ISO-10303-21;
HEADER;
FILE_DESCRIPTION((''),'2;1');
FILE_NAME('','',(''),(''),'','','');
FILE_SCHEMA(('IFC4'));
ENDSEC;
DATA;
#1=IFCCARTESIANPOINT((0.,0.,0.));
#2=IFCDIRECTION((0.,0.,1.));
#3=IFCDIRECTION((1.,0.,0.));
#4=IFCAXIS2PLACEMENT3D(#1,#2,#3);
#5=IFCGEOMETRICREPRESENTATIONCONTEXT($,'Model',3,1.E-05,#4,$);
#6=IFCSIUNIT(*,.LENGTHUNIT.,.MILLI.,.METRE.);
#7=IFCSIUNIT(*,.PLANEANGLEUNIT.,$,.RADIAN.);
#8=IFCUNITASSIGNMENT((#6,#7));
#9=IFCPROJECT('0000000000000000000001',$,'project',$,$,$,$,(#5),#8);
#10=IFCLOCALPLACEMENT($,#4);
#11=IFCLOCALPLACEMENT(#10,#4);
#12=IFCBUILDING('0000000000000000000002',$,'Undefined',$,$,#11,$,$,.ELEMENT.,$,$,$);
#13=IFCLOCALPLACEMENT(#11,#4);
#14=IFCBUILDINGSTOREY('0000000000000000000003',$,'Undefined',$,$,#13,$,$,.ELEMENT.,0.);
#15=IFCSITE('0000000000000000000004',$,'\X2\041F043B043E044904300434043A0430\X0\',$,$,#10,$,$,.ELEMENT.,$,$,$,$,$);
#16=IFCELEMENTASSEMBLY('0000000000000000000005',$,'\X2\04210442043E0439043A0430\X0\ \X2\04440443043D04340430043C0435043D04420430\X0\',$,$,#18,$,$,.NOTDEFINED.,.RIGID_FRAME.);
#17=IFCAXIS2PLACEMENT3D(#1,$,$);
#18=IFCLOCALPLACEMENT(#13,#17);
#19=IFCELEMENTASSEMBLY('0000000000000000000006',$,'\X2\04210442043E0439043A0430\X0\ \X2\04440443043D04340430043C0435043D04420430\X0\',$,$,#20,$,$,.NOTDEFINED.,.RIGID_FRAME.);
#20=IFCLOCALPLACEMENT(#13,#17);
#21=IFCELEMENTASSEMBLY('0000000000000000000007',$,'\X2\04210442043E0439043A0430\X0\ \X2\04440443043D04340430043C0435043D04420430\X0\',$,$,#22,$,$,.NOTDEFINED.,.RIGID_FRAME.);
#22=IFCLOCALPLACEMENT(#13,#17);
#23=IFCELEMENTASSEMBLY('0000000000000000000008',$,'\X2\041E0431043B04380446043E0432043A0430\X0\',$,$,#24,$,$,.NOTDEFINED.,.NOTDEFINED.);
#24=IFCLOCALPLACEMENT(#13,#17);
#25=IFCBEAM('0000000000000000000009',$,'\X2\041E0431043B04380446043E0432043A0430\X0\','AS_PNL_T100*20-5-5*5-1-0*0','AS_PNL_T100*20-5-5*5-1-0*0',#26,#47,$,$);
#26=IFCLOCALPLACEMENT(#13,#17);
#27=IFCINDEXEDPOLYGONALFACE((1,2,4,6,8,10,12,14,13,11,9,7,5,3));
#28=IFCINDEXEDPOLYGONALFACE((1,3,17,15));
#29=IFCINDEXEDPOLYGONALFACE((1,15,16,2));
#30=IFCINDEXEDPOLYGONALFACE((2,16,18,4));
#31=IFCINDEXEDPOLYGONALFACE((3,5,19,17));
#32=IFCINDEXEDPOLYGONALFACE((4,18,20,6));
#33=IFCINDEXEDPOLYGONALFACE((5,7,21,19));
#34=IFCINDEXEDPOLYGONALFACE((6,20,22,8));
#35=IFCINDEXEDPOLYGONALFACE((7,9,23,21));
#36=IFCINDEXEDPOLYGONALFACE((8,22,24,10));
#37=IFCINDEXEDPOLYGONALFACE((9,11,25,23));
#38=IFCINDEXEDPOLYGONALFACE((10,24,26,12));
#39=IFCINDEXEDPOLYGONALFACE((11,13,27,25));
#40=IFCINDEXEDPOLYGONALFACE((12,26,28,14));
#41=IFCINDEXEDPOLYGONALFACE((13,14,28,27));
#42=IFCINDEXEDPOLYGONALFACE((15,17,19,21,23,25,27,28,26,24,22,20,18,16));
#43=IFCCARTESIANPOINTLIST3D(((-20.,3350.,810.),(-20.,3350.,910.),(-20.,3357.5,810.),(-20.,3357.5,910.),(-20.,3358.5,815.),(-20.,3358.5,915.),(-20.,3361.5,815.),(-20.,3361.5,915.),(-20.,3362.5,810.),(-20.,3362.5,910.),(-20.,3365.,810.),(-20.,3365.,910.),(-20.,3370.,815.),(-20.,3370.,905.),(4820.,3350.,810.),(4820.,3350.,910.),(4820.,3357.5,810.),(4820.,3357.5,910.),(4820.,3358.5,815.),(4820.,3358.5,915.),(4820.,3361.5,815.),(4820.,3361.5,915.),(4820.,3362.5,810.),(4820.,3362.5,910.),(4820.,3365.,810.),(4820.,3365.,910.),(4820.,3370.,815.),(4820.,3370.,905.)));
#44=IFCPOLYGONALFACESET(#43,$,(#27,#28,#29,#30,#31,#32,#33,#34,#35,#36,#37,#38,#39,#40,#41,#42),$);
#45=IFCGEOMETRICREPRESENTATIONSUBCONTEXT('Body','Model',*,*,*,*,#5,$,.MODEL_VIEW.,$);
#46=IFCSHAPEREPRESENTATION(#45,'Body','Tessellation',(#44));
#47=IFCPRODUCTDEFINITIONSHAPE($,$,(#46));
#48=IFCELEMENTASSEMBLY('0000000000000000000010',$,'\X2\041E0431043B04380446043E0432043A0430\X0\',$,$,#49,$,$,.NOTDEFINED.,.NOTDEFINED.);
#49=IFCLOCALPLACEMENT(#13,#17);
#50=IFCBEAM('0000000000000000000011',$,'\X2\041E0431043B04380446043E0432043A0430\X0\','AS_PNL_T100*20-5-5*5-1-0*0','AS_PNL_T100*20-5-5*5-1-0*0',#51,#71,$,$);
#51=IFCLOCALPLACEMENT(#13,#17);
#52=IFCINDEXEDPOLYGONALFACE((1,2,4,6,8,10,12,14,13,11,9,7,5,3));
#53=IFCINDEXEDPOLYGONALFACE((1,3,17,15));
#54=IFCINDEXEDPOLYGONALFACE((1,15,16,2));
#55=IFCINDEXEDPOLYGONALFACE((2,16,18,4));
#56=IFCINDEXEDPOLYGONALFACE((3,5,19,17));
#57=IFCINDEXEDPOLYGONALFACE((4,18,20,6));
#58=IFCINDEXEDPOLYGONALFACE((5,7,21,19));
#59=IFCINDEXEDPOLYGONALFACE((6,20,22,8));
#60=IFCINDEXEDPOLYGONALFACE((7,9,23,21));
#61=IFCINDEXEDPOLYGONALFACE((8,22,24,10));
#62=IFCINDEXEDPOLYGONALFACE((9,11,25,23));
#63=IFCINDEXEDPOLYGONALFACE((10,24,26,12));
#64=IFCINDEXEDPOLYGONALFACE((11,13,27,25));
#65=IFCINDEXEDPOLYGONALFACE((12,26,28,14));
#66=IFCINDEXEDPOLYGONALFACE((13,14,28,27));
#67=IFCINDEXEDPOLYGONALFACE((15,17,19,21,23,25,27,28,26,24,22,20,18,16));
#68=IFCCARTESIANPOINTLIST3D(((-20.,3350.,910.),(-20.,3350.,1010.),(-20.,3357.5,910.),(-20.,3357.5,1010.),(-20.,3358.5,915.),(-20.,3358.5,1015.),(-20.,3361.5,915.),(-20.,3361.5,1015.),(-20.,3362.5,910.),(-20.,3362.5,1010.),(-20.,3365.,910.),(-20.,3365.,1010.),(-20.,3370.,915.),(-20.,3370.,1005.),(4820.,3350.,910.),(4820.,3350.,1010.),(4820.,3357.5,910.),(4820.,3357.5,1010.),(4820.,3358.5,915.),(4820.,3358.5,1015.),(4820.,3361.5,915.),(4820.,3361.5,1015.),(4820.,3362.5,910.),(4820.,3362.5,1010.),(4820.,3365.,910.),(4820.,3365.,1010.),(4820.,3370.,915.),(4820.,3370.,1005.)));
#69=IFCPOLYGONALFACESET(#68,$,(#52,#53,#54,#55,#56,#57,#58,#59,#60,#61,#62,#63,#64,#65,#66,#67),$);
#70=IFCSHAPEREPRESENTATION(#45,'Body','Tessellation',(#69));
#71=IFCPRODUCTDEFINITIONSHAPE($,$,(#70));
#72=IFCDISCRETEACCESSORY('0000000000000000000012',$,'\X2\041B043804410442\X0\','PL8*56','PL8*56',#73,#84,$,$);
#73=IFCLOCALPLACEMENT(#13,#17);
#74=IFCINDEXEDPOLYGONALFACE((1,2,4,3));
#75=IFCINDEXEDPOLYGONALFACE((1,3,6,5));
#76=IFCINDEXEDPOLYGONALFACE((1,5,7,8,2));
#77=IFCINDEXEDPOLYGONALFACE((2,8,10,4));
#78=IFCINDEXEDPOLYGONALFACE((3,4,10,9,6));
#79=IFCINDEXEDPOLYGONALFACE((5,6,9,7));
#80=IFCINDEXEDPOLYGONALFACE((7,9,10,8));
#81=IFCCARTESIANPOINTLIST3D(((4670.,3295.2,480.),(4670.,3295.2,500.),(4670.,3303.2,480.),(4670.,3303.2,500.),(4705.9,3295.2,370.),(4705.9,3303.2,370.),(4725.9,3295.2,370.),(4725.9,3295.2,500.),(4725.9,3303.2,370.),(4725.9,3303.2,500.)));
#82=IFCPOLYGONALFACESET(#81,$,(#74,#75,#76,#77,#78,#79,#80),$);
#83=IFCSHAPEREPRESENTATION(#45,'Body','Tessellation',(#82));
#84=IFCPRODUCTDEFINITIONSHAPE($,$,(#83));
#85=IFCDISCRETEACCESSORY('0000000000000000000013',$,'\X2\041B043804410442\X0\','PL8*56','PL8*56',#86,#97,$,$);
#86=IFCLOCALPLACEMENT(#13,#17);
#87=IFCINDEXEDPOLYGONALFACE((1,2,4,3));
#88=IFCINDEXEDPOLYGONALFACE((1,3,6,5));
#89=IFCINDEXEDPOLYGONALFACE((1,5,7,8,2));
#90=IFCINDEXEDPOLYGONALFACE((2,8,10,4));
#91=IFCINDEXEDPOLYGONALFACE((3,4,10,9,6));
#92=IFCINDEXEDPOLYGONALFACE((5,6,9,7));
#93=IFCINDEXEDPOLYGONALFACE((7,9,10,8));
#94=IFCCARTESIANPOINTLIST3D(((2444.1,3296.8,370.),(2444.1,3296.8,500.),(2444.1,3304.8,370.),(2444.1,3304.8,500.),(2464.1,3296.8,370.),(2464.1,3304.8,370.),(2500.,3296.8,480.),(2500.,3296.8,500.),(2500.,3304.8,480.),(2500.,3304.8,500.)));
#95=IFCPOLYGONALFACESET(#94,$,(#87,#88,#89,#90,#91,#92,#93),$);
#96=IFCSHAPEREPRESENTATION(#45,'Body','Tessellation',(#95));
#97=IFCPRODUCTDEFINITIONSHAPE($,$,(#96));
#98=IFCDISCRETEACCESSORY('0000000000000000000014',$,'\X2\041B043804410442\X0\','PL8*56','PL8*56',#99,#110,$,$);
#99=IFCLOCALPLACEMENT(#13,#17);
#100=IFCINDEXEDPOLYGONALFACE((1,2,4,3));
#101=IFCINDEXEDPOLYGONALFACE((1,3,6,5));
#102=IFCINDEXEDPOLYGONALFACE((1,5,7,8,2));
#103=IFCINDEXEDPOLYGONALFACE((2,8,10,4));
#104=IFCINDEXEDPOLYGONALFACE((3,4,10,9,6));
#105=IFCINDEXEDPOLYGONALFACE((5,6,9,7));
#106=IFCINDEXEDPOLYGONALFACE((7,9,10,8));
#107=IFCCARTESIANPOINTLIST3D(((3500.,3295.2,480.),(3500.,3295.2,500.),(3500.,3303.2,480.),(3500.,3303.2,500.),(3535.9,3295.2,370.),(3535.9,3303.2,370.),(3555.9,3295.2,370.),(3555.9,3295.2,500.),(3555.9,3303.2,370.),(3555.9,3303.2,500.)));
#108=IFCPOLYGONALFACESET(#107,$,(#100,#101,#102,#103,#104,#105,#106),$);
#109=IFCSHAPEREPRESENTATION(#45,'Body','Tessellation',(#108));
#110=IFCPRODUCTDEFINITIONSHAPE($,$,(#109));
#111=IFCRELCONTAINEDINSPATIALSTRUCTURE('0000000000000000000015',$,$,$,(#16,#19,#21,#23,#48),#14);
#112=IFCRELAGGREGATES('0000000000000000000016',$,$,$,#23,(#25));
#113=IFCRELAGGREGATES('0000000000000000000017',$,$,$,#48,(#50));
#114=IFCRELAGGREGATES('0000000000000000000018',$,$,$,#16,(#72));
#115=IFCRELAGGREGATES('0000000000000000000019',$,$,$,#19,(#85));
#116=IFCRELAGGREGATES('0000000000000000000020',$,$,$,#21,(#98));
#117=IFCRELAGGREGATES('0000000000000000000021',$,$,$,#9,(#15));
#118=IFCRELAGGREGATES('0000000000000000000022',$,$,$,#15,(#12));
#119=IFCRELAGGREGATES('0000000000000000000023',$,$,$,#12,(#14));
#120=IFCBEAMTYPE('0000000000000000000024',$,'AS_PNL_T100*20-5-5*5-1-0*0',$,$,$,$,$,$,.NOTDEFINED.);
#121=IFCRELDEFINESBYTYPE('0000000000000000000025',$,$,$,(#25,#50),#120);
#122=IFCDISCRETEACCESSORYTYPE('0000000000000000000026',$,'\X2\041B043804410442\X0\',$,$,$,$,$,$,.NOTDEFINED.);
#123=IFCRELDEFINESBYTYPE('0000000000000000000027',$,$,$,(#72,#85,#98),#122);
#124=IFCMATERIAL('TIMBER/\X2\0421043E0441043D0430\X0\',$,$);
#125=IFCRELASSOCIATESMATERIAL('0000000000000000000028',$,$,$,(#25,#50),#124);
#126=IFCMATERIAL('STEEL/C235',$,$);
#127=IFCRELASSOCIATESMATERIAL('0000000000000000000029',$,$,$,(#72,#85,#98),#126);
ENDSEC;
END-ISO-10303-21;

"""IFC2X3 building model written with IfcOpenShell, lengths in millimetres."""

from ifc_helpers import new_model, si_unit, frame, origin_with_axes, place, context, subcontext, project, spatial, polyline, outline, extrude, material, type_object, element, aggregate, save


model = new_model("IFC2X3")

# Units and contexts
model_context = context("Model", 3, precision=1e-05, world=origin_with_axes())
body_context = subcontext(model_context, "Body", "Model", "MODEL_VIEW")
ifc_project = project(units=[si_unit("LENGTHUNIT", "METRE", prefix="MILLI"), si_unit("PLANEANGLEUNIT", "RADIAN")], contexts=[model_context])

# Site, building, storey
site_placement = place(None, origin_with_axes())
site = spatial("IfcSite", under=ifc_project, at=site_placement, Name="Площадка", CompositionType="ELEMENT")
building_placement = place(site_placement, origin_with_axes())
building = spatial("IfcBuilding", under=site, at=building_placement, Name="Undefined", CompositionType="ELEMENT")
storey_placement = place(building_placement, origin_with_axes())
storey = spatial("IfcBuildingStorey", under=building, at=storey_placement, Name="Undefined", CompositionType="ELEMENT", Elevation=0.0)

# Element assemblies
assembly_1_placement = place(storey_placement, origin_with_axes())
assembly_1 = element("IfcElementAssembly", 1, at=assembly_1_placement, inside=storey, Name="Стойка фундамента", AssemblyPlace="NOTDEFINED", PredefinedType="RIGID_FRAME")
ifc_material_1 = material(Name="STEEL/C235")
assembly_2_placement = place(storey_placement, origin_with_axes())
assembly_2 = element("IfcElementAssembly", 2, at=assembly_2_placement, inside=storey, Name="Стойка фундамента", AssemblyPlace="NOTDEFINED", PredefinedType="RIGID_FRAME")
assembly_3_placement = place(storey_placement, origin_with_axes())
assembly_3 = element("IfcElementAssembly", 3, at=assembly_3_placement, inside=storey, Name="Стойка фундамента", AssemblyPlace="NOTDEFINED", PredefinedType="RIGID_FRAME")

# Shared definitions
ifc_material_2 = material(Name="TIMBER/Сосна")

# Element assemblies, beams
beam_type_1 = type_object("IfcBeamType", Name="AS_PNL_T100*20-5-5*5-1-0*0", PredefinedType="NOTDEFINED")
assembly_4_placement = place(storey_placement, origin_with_axes())
assembly_4 = element("IfcElementAssembly", 4, at=assembly_4_placement, inside=storey, Name="Облицовка", AssemblyPlace="NOTDEFINED", PredefinedType="NOTDEFINED")
beam_1_placement = place(assembly_4_placement, frame((4820.0, 3360.0, 860.0), z_axis=(0.0, 0.0, 1.0), x_axis=(-1.0, 0.0, 0.0)))
beam_1 = element("IfcBeam", 5, at=beam_1_placement, type_object=beam_type_1, material=ifc_material_2, Name="Облицовка", Description="AS_PNL_T100*20-5-5*5-1-0*0", ObjectType="AS_PNL_T100*20-5-5*5-1-0*0", context=body_context, shape_type="SweptSolid", body=[
    extrude(outline(polyline([(-2.5, -50.0), (-10.0, -50.0), (-10.0, 50.0), (-2.5, 50.0), (-1.5, 55.0), (1.5, 55.0), (2.5, 50.0), (5.0, 50.0), (10.0, 45.0), (10.0, -45.0), (5.0, -50.0), (2.5, -50.0), (1.5, -45.0), (-1.5, -45.0), (-2.5, -50.0)])), frame((4840.0, 0.0, 0.0), z_axis=(-1.0, 0.0, 0.0), x_axis=(0.0, -1.0, 0.0)), (0.0, 0.0, 1.0), 4840.0),
])
aggregate(assembly_4, [beam_1])
assembly_5_placement = place(storey_placement, origin_with_axes())
assembly_5 = element("IfcElementAssembly", 6, at=assembly_5_placement, inside=storey, Name="Облицовка", AssemblyPlace="NOTDEFINED", PredefinedType="NOTDEFINED")
beam_2_placement = place(assembly_5_placement, frame((4820.0, 3360.0, 960.0), z_axis=(0.0, 0.0, 1.0), x_axis=(-1.0, 0.0, 0.0)))
beam_2 = element("IfcBeam", 7, at=beam_2_placement, type_object=beam_type_1, material=ifc_material_2, Name="Облицовка", Description="AS_PNL_T100*20-5-5*5-1-0*0", ObjectType="AS_PNL_T100*20-5-5*5-1-0*0", context=body_context, shape_type="SweptSolid", body=[
    extrude(outline(polyline([(-2.5, -50.0), (-10.0, -50.0), (-10.0, 50.0), (-2.5, 50.0), (-1.5, 55.0), (1.5, 55.0), (2.5, 50.0), (5.0, 50.0), (10.0, 45.0), (10.0, -45.0), (5.0, -50.0), (2.5, -50.0), (1.5, -45.0), (-1.5, -45.0), (-2.5, -50.0)])), frame((4840.0, 0.0, 0.0), z_axis=(-1.0, 0.0, 0.0), x_axis=(0.0, -1.0, 0.0)), (0.0, 0.0, 1.0), 4840.0),
])
aggregate(assembly_5, [beam_2])

# Discrete accessories
discrete_accessory_type = type_object("IfcDiscreteAccessoryType", Name="Лист")
discrete_accessory_1_placement = place(assembly_1_placement, frame((4725.9, 3299.2, 500.0), z_axis=(0.0, -1.0, 0.0), x_axis=(-1.0, 0.0, 0.0)))
discrete_accessory_1 = element("IfcDiscreteAccessory", 8, at=discrete_accessory_1_placement, type_object=discrete_accessory_type, material=ifc_material_1, Name="Лист", Description="PL8*56", ObjectType="PL8*56", context=body_context, shape_type="SweptSolid", body=[
    extrude(outline(polyline([(0.0, 0.0), (55.9, 0.0), (55.9, 20.0), (20.0, 130.0), (0.0, 130.0), (0.0, 0.0)])), frame((0.0, 0.0, -4.0), z_axis=(0.0, 0.0, 1.0), x_axis=(1.0, 0.0, 0.0)), (0.0, 0.0, 1.0), 8.0),
])
aggregate(assembly_1, [discrete_accessory_1])
discrete_accessory_2_placement = place(assembly_2_placement, frame((2444.1, 3300.8, 500.0), z_axis=(0.0, 1.0, 0.0), x_axis=(1.0, 0.0, 0.0)))
discrete_accessory_2 = element("IfcDiscreteAccessory", 9, at=discrete_accessory_2_placement, type_object=discrete_accessory_type, material=ifc_material_1, Name="Лист", Description="PL8*56", ObjectType="PL8*56", context=body_context, shape_type="SweptSolid", body=[
    extrude(outline(polyline([(0.0, 0.0), (55.9, 0.0), (55.9, 20.0), (20.0, 130.0), (0.0, 130.0), (0.0, 0.0)])), frame((0.0, 0.0, -4.0), z_axis=(0.0, 0.0, 1.0), x_axis=(1.0, 0.0, 0.0)), (0.0, 0.0, 1.0), 8.0),
])
aggregate(assembly_2, [discrete_accessory_2])
discrete_accessory_3_placement = place(assembly_3_placement, frame((3555.9, 3299.2, 500.0), z_axis=(0.0, -1.0, 0.0), x_axis=(-1.0, 0.0, 0.0)))
discrete_accessory_3 = element("IfcDiscreteAccessory", 10, at=discrete_accessory_3_placement, type_object=discrete_accessory_type, material=ifc_material_1, Name="Лист", Description="PL8*56", ObjectType="PL8*56", context=body_context, shape_type="SweptSolid", body=[
    extrude(outline(polyline([(0.0, 0.0), (55.9, 0.0), (55.9, 20.0), (20.0, 130.0), (0.0, 130.0), (0.0, 0.0)])), frame((0.0, 0.0, -4.0), z_axis=(0.0, 0.0, 1.0), x_axis=(1.0, 0.0, 0.0)), (0.0, 0.0, 1.0), 8.0),
])
aggregate(assembly_3, [discrete_accessory_3])

save(model, "model.ifc")
